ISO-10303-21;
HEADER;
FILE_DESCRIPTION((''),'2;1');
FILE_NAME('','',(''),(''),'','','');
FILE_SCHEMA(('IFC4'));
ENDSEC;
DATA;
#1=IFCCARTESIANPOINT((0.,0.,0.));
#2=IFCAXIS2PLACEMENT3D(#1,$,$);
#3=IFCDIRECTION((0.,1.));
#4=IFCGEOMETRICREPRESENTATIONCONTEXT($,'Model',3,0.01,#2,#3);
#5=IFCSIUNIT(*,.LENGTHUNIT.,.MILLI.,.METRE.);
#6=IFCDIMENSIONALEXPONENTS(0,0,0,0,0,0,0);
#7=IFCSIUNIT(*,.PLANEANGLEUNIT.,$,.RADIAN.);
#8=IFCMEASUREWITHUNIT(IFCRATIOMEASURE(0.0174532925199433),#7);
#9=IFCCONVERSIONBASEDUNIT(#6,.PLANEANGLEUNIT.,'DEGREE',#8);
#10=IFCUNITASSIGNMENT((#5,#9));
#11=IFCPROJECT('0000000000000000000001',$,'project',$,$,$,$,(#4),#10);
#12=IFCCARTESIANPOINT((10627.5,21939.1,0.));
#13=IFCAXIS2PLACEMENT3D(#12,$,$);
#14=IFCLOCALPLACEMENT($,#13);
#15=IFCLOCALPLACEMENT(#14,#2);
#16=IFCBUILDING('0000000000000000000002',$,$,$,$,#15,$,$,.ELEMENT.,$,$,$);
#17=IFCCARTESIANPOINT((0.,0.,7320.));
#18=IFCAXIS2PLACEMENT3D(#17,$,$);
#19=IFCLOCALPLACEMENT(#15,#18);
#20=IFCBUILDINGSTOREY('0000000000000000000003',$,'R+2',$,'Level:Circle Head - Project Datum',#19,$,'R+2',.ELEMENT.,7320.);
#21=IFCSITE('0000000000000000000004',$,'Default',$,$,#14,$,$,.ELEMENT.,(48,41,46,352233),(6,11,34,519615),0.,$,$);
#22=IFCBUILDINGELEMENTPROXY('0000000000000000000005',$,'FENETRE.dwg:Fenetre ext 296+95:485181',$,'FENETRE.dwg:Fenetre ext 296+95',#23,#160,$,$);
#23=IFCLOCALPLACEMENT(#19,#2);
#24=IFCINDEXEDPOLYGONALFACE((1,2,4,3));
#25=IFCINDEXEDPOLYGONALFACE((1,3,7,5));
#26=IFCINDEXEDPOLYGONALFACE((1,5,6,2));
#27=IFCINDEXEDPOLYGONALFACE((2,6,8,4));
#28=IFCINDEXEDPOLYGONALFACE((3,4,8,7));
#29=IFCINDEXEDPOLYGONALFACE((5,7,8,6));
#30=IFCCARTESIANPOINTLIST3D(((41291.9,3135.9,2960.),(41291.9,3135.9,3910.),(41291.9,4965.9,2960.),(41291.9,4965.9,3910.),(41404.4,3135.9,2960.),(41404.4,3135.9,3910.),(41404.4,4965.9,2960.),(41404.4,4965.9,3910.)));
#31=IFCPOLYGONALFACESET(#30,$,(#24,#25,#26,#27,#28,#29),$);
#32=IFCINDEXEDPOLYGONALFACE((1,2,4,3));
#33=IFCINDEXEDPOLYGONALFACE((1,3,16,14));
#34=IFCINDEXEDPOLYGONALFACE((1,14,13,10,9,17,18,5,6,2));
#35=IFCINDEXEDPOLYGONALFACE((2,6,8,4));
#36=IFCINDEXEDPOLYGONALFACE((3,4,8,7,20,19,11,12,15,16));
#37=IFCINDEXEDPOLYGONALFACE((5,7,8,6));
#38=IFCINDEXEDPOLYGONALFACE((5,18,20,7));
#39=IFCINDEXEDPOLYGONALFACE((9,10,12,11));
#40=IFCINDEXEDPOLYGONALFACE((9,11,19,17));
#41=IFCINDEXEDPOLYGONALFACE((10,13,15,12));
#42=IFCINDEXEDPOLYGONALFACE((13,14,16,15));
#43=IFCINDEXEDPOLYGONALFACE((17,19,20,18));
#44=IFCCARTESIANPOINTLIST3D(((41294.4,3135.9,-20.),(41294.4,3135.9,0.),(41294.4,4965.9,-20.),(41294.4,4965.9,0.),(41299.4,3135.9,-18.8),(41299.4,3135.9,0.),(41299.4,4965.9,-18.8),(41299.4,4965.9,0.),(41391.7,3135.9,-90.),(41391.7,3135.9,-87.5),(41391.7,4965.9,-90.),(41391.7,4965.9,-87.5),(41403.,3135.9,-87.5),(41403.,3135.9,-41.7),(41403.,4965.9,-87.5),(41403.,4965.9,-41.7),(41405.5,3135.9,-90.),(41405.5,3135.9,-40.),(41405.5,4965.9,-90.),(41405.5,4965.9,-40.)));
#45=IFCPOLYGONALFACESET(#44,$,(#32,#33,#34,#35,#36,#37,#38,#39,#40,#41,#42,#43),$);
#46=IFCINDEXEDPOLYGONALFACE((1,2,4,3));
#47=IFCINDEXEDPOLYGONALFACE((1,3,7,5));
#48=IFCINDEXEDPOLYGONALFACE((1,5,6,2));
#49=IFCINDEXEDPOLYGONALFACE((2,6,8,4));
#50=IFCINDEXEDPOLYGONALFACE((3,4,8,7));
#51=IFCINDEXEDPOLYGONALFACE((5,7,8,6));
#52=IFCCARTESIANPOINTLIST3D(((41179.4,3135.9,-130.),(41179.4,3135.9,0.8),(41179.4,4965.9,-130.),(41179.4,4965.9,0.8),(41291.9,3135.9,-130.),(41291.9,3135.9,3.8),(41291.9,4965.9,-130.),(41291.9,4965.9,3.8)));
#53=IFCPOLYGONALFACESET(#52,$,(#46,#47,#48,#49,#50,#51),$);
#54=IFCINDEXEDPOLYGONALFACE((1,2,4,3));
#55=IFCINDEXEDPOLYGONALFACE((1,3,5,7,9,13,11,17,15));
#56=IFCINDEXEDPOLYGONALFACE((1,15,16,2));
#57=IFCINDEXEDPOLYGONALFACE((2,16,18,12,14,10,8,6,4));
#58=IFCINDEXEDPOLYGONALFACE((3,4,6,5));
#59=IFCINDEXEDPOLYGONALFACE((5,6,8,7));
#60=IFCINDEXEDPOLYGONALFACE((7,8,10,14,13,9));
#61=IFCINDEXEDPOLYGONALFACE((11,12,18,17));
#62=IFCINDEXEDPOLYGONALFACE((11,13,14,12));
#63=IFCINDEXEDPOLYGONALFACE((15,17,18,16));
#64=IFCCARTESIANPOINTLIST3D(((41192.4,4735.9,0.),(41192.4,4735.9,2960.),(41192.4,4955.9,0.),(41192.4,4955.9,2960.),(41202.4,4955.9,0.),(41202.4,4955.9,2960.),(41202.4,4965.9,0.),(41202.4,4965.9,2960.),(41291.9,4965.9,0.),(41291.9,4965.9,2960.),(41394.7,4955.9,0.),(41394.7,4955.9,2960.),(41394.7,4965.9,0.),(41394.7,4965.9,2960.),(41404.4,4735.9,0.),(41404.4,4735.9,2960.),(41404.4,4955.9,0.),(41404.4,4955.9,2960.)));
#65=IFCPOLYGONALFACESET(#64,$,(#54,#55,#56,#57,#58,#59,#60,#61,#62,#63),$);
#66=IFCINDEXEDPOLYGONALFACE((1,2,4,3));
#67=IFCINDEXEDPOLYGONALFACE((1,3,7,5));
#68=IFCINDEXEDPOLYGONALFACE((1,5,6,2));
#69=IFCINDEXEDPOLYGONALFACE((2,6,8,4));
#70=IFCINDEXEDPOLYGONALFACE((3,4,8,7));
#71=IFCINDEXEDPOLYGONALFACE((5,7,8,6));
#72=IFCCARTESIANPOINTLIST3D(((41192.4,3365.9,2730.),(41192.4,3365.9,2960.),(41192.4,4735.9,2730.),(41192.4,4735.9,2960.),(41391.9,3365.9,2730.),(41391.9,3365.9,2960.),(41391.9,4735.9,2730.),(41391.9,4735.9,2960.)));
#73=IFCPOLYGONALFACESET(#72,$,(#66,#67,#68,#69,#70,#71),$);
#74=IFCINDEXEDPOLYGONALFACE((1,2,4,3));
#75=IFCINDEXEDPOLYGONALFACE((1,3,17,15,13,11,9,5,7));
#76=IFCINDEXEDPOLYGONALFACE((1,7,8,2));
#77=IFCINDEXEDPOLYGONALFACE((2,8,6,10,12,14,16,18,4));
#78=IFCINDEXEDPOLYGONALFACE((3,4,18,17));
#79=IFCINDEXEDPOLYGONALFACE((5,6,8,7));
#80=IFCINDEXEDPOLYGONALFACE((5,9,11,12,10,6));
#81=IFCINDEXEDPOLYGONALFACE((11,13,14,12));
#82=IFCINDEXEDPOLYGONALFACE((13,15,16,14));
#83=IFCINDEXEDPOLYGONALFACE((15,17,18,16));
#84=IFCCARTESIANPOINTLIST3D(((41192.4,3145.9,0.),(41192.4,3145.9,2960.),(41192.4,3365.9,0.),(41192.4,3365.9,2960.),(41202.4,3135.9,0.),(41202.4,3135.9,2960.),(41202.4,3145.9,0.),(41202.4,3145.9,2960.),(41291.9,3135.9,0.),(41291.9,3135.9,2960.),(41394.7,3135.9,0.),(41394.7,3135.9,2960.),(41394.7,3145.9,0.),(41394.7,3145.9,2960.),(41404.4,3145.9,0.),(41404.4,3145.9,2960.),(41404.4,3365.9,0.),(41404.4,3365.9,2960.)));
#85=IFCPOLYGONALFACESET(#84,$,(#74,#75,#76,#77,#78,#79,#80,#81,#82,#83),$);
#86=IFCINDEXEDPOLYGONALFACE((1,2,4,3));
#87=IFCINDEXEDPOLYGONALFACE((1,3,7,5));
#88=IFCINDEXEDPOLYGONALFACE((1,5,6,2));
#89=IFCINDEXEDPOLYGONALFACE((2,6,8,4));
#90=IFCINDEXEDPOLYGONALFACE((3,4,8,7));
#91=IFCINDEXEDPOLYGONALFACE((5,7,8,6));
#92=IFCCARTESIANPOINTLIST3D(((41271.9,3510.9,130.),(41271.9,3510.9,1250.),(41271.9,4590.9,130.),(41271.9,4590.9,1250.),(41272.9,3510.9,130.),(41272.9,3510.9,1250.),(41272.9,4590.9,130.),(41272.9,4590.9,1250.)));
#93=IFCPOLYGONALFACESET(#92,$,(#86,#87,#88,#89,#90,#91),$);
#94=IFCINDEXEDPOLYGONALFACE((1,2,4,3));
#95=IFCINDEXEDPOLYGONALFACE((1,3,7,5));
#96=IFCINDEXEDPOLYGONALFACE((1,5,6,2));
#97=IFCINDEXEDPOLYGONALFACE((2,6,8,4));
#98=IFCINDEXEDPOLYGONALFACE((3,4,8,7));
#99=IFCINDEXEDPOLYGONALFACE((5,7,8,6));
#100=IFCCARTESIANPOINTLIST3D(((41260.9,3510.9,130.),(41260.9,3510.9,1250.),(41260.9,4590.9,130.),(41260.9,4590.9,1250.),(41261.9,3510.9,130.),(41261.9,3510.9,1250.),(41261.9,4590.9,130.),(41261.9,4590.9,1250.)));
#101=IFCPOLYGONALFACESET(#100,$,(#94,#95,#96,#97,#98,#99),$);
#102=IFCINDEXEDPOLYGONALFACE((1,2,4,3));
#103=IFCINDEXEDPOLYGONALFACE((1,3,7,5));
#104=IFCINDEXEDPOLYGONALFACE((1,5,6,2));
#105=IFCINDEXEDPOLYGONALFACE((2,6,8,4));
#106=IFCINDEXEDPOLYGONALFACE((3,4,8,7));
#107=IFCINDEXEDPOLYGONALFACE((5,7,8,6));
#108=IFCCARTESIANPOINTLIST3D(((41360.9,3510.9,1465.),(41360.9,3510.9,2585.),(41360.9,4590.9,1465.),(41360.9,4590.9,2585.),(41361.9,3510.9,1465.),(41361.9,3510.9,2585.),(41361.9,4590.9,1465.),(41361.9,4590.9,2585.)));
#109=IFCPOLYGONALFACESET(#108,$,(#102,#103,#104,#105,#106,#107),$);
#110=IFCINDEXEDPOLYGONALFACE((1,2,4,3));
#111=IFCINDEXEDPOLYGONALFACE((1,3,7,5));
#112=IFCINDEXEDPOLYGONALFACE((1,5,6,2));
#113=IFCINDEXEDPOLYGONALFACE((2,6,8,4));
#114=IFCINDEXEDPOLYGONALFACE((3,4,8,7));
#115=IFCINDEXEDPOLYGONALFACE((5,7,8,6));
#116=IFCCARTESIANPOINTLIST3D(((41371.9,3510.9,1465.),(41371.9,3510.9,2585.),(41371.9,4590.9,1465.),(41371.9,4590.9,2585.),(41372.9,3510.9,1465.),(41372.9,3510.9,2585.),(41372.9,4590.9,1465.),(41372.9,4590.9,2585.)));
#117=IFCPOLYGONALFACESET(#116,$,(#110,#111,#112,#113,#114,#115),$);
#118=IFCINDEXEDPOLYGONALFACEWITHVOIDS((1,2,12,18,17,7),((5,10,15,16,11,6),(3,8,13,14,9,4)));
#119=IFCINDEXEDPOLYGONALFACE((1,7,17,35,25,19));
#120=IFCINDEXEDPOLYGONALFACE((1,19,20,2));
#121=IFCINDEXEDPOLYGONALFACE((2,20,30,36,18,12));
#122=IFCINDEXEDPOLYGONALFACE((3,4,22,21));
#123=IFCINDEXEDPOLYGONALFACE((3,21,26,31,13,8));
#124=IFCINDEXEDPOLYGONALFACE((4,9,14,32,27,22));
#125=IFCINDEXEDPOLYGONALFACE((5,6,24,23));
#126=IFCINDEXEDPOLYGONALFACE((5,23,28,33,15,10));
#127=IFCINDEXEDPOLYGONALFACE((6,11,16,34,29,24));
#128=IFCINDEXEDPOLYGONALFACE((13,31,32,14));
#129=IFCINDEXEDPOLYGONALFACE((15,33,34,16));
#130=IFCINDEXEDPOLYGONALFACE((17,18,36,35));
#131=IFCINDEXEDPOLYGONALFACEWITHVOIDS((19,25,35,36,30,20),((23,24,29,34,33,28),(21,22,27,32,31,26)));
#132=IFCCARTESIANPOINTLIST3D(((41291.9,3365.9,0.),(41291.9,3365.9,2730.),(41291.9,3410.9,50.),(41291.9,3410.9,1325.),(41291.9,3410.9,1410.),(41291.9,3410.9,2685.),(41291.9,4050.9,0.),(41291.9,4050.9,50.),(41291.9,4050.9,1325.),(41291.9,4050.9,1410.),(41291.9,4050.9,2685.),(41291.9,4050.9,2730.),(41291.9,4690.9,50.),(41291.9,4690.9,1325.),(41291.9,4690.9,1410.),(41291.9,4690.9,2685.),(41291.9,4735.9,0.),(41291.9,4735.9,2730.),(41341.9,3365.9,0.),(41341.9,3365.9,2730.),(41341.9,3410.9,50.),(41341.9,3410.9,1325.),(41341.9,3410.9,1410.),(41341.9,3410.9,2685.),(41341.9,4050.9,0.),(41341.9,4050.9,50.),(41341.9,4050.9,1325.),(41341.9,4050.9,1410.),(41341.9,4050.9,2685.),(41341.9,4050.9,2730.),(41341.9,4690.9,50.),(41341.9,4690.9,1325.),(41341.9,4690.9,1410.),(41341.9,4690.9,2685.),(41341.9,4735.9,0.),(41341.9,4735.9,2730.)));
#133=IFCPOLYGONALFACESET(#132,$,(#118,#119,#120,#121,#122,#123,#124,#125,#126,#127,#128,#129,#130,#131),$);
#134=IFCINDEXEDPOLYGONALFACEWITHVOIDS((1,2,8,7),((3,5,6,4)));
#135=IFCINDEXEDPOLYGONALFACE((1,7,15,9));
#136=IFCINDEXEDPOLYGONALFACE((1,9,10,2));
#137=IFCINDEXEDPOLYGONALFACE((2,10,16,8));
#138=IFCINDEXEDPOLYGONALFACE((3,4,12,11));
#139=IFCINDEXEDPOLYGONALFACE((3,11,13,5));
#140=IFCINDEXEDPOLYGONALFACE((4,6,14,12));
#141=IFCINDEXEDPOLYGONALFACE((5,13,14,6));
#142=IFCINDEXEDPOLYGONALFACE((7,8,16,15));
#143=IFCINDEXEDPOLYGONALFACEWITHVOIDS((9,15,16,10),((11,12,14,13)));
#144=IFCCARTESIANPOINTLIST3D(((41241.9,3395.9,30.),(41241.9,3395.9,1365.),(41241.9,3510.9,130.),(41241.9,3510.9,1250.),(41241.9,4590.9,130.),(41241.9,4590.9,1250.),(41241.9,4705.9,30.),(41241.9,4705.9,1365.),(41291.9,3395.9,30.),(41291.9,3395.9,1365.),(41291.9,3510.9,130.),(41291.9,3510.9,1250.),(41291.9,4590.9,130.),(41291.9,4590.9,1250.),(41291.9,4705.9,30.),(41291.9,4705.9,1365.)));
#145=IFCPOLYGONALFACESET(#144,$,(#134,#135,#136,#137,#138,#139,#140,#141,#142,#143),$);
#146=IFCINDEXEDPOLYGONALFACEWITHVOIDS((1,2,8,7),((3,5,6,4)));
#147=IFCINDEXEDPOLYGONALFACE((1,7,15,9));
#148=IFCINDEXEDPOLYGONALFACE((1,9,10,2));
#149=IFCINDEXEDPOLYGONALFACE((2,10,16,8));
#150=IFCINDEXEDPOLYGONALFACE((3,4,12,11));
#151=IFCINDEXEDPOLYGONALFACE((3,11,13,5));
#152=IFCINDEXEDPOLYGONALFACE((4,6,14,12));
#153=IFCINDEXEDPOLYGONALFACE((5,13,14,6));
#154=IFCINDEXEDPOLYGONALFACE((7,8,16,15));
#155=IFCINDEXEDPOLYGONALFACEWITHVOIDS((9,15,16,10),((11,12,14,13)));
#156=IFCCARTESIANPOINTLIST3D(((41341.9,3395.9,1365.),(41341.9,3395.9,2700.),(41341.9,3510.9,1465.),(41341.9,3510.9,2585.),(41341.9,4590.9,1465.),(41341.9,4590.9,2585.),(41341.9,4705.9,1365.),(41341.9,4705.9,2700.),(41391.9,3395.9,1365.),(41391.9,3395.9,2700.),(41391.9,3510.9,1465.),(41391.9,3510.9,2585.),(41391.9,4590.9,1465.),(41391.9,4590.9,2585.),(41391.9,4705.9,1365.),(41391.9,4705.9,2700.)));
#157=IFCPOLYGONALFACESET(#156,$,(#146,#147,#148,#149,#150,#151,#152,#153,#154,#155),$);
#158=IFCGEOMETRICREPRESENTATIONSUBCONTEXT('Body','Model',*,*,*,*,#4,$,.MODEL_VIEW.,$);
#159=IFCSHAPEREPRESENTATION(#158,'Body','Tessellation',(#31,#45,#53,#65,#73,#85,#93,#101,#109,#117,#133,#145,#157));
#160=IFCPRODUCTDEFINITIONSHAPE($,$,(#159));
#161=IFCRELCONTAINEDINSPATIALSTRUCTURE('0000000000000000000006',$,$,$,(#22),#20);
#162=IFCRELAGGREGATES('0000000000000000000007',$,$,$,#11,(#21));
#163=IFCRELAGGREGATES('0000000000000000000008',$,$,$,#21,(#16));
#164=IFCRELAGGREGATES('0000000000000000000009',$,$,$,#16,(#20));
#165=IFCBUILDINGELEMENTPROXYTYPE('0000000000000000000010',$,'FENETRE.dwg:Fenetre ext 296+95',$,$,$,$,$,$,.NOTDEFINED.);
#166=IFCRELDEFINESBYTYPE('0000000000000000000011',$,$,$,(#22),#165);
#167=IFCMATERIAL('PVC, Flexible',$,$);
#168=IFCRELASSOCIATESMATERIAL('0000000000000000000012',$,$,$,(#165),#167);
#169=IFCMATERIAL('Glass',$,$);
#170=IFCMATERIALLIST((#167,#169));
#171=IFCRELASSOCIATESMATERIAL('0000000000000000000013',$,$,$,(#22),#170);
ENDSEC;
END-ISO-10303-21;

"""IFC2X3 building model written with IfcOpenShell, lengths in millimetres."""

from ifc_helpers import new_model, entity, si_unit, converted_unit, direction, frame, frame_2d, origin, origin_2d_with_axis, place, context, subcontext, project, spatial, polyline, rectangle, outline, extrude, source, transform, mapped, material, material_list, type_object, type_shapes, element, save


model = new_model("IFC2X3")

# Units and contexts
model_context = context("Model", 3, precision=0.01, world=origin(), true_north=direction((0.0, 1.0)))
body_context = subcontext(model_context, "Body", "Model", "MODEL_VIEW")
ifc_project = project(units=[si_unit("LENGTHUNIT", "METRE", prefix="MILLI"), converted_unit("PLANEANGLEUNIT", "DEGREE", entity("IfcRatioMeasure", 0.0174532925199433), si_unit("PLANEANGLEUNIT", "RADIAN"), dimensions=[0, 0, 0, 0, 0, 0, 0])], contexts=[model_context])

# Site, building, storey
site_placement = place(None, frame((10627.5, 21939.1, 0.0)))
site = spatial("IfcSite", under=ifc_project, at=site_placement, Name="Default", CompositionType="ELEMENT", RefLatitude=(48, 41, 46, 352233), RefLongitude=(6, 11, 34, 519615), RefElevation=0.0)
building_placement = place(site_placement, origin())
building = spatial("IfcBuilding", under=site, at=building_placement, CompositionType="ELEMENT")
storey_placement = place(building_placement, frame((0.0, 0.0, 7320.0)))
storey = spatial("IfcBuildingStorey", under=building, at=storey_placement, Name="R+2", ObjectType="Level:Circle Head - Project Datum", LongName="R+2", CompositionType="ELEMENT", Elevation=7320.0)

# Building element proxy
ifc_material_1 = material(Name="PVC, Flexible")
ifc_material_2 = material(Name="Glass")
building_element_proxy_type_1 = type_object("IfcBuildingElementProxyType", Name="FENETRE.dwg:Fenetre ext 296+95", PredefinedType="NOTDEFINED", material=ifc_material_1)
shared_shape_1 = source(origin(), body_context, "Body", "SweptSolid", [
    extrude(rectangle(XDim=112.5, YDim=1830.0, at=origin_2d_with_axis()), frame((-10.4, -56.3, 2960.0), z_axis=(0.0, 0.0, 1.0), x_axis=(0.0, 1.0, 0.0)), (0.0, 0.0, 1.0), 950.0),
    extrude(outline(polyline([(27.5, -64.4), (47.5, -64.4), (47.5, -59.4), (28.8, -59.4), (7.5, 46.7), (-42.5, 46.7), (-42.5, 32.9), (-40.0, 32.9), (-40.0, 44.2), (5.8, 44.2), (27.5, -64.4)])), frame((-925.4, -66.9, -47.5), z_axis=(1.0, 0.0, 0.0), x_axis=(0.0, 0.0, 1.0)), (0.0, 0.0, 1.0), 1830.0),
    extrude(outline(polyline([(-54.5, -66.1), (58.0, -66.1), (54.5, 67.6), (-58.0, 64.6), (-54.5, -66.1)])), frame((-925.4, 56.3, -63.8), z_axis=(1.0, 0.0, 0.0), x_axis=(0.0, -0.999645, 0.02665)), (0.0, 0.0, 1.0), 1830.0),
    extrude(outline(polyline([(-97.0, -55.6), (5.9, -55.6), (95.4, -55.6), (95.4, -45.6), (105.4, -45.6), (105.4, 174.4), (-106.6, 174.4), (-106.6, -45.6), (-97.0, -45.6), (-97.0, -55.6)])), frame((849.0, -5.9, 0.0), z_axis=(0.0, 0.0, 1.0), x_axis=(0.0, 1.0, 0.0)), (0.0, 0.0, 1.0), 2960.0),
    extrude(rectangle(XDim=1370.0, YDim=199.5, at=origin_2d_with_axis()), frame((-10.4, -0.3, 2730.0), z_axis=(0.0, 0.0, 1.0), x_axis=(-1.0, 0.0, 0.0)), (0.0, 0.0, 1.0), 230.0),
    extrude(outline(polyline([(-55.6, 97.0), (-55.6, -5.9), (-55.6, -95.4), (-45.6, -95.4), (-45.6, -105.4), (174.4, -105.4), (174.4, 106.6), (-45.6, 106.6), (-45.6, 97.0), (-55.6, 97.0)])), frame((-869.9, -5.9, 0.0), z_axis=(0.0, 0.0, -1.0), x_axis=(1.0, 0.0, 0.0)), (0.0, 0.0, -1.0), 2960.0),
    extrude(rectangle(XDim=1080.0, YDim=1.0, at=origin_2d_with_axis()), frame((-10.4, 19.5, 130.0), z_axis=(0.0, 0.0, 1.0), x_axis=(-1.0, 0.0, 0.0)), (0.0, 0.0, 1.0), 1120.0),
    extrude(rectangle(XDim=1080.0, YDim=1.0, at=origin_2d_with_axis()), frame((-10.4, 30.5, 130.0), z_axis=(0.0, 0.0, 1.0), x_axis=(-1.0, 0.0, 0.0)), (0.0, 0.0, 1.0), 1120.0),
    extrude(rectangle(XDim=1080.0, YDim=1.0, at=frame_2d((0.0, 0.0), x_axis=(1.0, 0.0))), frame((-10.4, -69.5, 1465.0), z_axis=(0.0, 0.0, 1.0), x_axis=(-1.0, 0.0, 0.0)), (0.0, 0.0, 1.0), 1120.0),
    extrude(rectangle(XDim=1080.0, YDim=1.0, at=frame_2d((0.0, 0.0), x_axis=(1.0, 0.0))), frame((-10.4, -80.5, 1465.0), z_axis=(0.0, 0.0, 1.0), x_axis=(-1.0, 0.0, 0.0)), (0.0, 0.0, 1.0), 1120.0),
    extrude(outline(polyline([(-685.0, -1365.0), (0.0, -1365.0), (685.0, -1365.0), (685.0, 1365.0), (0.0, 1365.0), (-685.0, 1365.0), (-685.0, -1365.0)]), holes=[polyline([(-640.0, -1320.0), (-640.0, -45.0), (0.0, -45.0), (640.0, -45.0), (640.0, -1320.0), (0.0, -1320.0), (-640.0, -1320.0)]), polyline([(-640.0, 40.0), (-640.0, 1315.0), (0.0, 1315.0), (640.0, 1315.0), (640.0, 40.0), (0.0, 40.0), (-640.0, 40.0)])]), frame((-10.4, -50.0, 1365.0), z_axis=(0.0, 1.0, 0.0), x_axis=(1.0, 0.0, 0.0)), (0.0, 0.0, 1.0), 50.0),
    extrude(outline(polyline([(-655.0, -667.5), (655.0, -667.5), (655.0, 667.5), (-655.0, 667.5), (-655.0, -667.5)]), holes=[polyline([(-540.0, 552.5), (540.0, 552.5), (540.0, -567.5), (-540.0, -567.5), (-540.0, 552.5)])]), frame((-10.4, 0.0, 697.5), z_axis=(0.0, 1.0, 0.0), x_axis=(-1.0, 0.0, 0.0)), (0.0, 0.0, 1.0), 50.0),
    extrude(outline(polyline([(-655.0, -667.5), (655.0, -667.5), (655.0, 667.5), (-655.0, 667.5), (-655.0, -667.5)]), holes=[polyline([(-540.0, 552.5), (540.0, 552.5), (540.0, -567.5), (-540.0, -567.5), (-540.0, 552.5)])]), frame((-10.4, -100.0, 2032.5), z_axis=(0.0, 1.0, 0.0), x_axis=(-1.0, 0.0, 0.0)), (0.0, 0.0, 1.0), 50.0),
])
type_shapes(building_element_proxy_type_1, [shared_shape_1])
ifc_material_list_1 = material_list([ifc_material_1, ifc_material_2])
proxy_1_placement = place(storey_placement, frame((41291.9, 4061.3, 0.0), z_axis=(0.0, 0.0, 1.0), x_axis=(0.0, 1.0, 0.0)))
element("IfcBuildingElementProxy", 1, at=proxy_1_placement, inside=storey, type_object=building_element_proxy_type_1, material=ifc_material_list_1, Name="FENETRE.dwg:Fenetre ext 296+95:485181", ObjectType="FENETRE.dwg:Fenetre ext 296+95", context=body_context, shape_type="MappedRepresentation", body=[
    mapped(shared_shape_1, transform((0.0, 0.0, 0.0), scale=1.0)),
])

save(model, "model.ifc")
